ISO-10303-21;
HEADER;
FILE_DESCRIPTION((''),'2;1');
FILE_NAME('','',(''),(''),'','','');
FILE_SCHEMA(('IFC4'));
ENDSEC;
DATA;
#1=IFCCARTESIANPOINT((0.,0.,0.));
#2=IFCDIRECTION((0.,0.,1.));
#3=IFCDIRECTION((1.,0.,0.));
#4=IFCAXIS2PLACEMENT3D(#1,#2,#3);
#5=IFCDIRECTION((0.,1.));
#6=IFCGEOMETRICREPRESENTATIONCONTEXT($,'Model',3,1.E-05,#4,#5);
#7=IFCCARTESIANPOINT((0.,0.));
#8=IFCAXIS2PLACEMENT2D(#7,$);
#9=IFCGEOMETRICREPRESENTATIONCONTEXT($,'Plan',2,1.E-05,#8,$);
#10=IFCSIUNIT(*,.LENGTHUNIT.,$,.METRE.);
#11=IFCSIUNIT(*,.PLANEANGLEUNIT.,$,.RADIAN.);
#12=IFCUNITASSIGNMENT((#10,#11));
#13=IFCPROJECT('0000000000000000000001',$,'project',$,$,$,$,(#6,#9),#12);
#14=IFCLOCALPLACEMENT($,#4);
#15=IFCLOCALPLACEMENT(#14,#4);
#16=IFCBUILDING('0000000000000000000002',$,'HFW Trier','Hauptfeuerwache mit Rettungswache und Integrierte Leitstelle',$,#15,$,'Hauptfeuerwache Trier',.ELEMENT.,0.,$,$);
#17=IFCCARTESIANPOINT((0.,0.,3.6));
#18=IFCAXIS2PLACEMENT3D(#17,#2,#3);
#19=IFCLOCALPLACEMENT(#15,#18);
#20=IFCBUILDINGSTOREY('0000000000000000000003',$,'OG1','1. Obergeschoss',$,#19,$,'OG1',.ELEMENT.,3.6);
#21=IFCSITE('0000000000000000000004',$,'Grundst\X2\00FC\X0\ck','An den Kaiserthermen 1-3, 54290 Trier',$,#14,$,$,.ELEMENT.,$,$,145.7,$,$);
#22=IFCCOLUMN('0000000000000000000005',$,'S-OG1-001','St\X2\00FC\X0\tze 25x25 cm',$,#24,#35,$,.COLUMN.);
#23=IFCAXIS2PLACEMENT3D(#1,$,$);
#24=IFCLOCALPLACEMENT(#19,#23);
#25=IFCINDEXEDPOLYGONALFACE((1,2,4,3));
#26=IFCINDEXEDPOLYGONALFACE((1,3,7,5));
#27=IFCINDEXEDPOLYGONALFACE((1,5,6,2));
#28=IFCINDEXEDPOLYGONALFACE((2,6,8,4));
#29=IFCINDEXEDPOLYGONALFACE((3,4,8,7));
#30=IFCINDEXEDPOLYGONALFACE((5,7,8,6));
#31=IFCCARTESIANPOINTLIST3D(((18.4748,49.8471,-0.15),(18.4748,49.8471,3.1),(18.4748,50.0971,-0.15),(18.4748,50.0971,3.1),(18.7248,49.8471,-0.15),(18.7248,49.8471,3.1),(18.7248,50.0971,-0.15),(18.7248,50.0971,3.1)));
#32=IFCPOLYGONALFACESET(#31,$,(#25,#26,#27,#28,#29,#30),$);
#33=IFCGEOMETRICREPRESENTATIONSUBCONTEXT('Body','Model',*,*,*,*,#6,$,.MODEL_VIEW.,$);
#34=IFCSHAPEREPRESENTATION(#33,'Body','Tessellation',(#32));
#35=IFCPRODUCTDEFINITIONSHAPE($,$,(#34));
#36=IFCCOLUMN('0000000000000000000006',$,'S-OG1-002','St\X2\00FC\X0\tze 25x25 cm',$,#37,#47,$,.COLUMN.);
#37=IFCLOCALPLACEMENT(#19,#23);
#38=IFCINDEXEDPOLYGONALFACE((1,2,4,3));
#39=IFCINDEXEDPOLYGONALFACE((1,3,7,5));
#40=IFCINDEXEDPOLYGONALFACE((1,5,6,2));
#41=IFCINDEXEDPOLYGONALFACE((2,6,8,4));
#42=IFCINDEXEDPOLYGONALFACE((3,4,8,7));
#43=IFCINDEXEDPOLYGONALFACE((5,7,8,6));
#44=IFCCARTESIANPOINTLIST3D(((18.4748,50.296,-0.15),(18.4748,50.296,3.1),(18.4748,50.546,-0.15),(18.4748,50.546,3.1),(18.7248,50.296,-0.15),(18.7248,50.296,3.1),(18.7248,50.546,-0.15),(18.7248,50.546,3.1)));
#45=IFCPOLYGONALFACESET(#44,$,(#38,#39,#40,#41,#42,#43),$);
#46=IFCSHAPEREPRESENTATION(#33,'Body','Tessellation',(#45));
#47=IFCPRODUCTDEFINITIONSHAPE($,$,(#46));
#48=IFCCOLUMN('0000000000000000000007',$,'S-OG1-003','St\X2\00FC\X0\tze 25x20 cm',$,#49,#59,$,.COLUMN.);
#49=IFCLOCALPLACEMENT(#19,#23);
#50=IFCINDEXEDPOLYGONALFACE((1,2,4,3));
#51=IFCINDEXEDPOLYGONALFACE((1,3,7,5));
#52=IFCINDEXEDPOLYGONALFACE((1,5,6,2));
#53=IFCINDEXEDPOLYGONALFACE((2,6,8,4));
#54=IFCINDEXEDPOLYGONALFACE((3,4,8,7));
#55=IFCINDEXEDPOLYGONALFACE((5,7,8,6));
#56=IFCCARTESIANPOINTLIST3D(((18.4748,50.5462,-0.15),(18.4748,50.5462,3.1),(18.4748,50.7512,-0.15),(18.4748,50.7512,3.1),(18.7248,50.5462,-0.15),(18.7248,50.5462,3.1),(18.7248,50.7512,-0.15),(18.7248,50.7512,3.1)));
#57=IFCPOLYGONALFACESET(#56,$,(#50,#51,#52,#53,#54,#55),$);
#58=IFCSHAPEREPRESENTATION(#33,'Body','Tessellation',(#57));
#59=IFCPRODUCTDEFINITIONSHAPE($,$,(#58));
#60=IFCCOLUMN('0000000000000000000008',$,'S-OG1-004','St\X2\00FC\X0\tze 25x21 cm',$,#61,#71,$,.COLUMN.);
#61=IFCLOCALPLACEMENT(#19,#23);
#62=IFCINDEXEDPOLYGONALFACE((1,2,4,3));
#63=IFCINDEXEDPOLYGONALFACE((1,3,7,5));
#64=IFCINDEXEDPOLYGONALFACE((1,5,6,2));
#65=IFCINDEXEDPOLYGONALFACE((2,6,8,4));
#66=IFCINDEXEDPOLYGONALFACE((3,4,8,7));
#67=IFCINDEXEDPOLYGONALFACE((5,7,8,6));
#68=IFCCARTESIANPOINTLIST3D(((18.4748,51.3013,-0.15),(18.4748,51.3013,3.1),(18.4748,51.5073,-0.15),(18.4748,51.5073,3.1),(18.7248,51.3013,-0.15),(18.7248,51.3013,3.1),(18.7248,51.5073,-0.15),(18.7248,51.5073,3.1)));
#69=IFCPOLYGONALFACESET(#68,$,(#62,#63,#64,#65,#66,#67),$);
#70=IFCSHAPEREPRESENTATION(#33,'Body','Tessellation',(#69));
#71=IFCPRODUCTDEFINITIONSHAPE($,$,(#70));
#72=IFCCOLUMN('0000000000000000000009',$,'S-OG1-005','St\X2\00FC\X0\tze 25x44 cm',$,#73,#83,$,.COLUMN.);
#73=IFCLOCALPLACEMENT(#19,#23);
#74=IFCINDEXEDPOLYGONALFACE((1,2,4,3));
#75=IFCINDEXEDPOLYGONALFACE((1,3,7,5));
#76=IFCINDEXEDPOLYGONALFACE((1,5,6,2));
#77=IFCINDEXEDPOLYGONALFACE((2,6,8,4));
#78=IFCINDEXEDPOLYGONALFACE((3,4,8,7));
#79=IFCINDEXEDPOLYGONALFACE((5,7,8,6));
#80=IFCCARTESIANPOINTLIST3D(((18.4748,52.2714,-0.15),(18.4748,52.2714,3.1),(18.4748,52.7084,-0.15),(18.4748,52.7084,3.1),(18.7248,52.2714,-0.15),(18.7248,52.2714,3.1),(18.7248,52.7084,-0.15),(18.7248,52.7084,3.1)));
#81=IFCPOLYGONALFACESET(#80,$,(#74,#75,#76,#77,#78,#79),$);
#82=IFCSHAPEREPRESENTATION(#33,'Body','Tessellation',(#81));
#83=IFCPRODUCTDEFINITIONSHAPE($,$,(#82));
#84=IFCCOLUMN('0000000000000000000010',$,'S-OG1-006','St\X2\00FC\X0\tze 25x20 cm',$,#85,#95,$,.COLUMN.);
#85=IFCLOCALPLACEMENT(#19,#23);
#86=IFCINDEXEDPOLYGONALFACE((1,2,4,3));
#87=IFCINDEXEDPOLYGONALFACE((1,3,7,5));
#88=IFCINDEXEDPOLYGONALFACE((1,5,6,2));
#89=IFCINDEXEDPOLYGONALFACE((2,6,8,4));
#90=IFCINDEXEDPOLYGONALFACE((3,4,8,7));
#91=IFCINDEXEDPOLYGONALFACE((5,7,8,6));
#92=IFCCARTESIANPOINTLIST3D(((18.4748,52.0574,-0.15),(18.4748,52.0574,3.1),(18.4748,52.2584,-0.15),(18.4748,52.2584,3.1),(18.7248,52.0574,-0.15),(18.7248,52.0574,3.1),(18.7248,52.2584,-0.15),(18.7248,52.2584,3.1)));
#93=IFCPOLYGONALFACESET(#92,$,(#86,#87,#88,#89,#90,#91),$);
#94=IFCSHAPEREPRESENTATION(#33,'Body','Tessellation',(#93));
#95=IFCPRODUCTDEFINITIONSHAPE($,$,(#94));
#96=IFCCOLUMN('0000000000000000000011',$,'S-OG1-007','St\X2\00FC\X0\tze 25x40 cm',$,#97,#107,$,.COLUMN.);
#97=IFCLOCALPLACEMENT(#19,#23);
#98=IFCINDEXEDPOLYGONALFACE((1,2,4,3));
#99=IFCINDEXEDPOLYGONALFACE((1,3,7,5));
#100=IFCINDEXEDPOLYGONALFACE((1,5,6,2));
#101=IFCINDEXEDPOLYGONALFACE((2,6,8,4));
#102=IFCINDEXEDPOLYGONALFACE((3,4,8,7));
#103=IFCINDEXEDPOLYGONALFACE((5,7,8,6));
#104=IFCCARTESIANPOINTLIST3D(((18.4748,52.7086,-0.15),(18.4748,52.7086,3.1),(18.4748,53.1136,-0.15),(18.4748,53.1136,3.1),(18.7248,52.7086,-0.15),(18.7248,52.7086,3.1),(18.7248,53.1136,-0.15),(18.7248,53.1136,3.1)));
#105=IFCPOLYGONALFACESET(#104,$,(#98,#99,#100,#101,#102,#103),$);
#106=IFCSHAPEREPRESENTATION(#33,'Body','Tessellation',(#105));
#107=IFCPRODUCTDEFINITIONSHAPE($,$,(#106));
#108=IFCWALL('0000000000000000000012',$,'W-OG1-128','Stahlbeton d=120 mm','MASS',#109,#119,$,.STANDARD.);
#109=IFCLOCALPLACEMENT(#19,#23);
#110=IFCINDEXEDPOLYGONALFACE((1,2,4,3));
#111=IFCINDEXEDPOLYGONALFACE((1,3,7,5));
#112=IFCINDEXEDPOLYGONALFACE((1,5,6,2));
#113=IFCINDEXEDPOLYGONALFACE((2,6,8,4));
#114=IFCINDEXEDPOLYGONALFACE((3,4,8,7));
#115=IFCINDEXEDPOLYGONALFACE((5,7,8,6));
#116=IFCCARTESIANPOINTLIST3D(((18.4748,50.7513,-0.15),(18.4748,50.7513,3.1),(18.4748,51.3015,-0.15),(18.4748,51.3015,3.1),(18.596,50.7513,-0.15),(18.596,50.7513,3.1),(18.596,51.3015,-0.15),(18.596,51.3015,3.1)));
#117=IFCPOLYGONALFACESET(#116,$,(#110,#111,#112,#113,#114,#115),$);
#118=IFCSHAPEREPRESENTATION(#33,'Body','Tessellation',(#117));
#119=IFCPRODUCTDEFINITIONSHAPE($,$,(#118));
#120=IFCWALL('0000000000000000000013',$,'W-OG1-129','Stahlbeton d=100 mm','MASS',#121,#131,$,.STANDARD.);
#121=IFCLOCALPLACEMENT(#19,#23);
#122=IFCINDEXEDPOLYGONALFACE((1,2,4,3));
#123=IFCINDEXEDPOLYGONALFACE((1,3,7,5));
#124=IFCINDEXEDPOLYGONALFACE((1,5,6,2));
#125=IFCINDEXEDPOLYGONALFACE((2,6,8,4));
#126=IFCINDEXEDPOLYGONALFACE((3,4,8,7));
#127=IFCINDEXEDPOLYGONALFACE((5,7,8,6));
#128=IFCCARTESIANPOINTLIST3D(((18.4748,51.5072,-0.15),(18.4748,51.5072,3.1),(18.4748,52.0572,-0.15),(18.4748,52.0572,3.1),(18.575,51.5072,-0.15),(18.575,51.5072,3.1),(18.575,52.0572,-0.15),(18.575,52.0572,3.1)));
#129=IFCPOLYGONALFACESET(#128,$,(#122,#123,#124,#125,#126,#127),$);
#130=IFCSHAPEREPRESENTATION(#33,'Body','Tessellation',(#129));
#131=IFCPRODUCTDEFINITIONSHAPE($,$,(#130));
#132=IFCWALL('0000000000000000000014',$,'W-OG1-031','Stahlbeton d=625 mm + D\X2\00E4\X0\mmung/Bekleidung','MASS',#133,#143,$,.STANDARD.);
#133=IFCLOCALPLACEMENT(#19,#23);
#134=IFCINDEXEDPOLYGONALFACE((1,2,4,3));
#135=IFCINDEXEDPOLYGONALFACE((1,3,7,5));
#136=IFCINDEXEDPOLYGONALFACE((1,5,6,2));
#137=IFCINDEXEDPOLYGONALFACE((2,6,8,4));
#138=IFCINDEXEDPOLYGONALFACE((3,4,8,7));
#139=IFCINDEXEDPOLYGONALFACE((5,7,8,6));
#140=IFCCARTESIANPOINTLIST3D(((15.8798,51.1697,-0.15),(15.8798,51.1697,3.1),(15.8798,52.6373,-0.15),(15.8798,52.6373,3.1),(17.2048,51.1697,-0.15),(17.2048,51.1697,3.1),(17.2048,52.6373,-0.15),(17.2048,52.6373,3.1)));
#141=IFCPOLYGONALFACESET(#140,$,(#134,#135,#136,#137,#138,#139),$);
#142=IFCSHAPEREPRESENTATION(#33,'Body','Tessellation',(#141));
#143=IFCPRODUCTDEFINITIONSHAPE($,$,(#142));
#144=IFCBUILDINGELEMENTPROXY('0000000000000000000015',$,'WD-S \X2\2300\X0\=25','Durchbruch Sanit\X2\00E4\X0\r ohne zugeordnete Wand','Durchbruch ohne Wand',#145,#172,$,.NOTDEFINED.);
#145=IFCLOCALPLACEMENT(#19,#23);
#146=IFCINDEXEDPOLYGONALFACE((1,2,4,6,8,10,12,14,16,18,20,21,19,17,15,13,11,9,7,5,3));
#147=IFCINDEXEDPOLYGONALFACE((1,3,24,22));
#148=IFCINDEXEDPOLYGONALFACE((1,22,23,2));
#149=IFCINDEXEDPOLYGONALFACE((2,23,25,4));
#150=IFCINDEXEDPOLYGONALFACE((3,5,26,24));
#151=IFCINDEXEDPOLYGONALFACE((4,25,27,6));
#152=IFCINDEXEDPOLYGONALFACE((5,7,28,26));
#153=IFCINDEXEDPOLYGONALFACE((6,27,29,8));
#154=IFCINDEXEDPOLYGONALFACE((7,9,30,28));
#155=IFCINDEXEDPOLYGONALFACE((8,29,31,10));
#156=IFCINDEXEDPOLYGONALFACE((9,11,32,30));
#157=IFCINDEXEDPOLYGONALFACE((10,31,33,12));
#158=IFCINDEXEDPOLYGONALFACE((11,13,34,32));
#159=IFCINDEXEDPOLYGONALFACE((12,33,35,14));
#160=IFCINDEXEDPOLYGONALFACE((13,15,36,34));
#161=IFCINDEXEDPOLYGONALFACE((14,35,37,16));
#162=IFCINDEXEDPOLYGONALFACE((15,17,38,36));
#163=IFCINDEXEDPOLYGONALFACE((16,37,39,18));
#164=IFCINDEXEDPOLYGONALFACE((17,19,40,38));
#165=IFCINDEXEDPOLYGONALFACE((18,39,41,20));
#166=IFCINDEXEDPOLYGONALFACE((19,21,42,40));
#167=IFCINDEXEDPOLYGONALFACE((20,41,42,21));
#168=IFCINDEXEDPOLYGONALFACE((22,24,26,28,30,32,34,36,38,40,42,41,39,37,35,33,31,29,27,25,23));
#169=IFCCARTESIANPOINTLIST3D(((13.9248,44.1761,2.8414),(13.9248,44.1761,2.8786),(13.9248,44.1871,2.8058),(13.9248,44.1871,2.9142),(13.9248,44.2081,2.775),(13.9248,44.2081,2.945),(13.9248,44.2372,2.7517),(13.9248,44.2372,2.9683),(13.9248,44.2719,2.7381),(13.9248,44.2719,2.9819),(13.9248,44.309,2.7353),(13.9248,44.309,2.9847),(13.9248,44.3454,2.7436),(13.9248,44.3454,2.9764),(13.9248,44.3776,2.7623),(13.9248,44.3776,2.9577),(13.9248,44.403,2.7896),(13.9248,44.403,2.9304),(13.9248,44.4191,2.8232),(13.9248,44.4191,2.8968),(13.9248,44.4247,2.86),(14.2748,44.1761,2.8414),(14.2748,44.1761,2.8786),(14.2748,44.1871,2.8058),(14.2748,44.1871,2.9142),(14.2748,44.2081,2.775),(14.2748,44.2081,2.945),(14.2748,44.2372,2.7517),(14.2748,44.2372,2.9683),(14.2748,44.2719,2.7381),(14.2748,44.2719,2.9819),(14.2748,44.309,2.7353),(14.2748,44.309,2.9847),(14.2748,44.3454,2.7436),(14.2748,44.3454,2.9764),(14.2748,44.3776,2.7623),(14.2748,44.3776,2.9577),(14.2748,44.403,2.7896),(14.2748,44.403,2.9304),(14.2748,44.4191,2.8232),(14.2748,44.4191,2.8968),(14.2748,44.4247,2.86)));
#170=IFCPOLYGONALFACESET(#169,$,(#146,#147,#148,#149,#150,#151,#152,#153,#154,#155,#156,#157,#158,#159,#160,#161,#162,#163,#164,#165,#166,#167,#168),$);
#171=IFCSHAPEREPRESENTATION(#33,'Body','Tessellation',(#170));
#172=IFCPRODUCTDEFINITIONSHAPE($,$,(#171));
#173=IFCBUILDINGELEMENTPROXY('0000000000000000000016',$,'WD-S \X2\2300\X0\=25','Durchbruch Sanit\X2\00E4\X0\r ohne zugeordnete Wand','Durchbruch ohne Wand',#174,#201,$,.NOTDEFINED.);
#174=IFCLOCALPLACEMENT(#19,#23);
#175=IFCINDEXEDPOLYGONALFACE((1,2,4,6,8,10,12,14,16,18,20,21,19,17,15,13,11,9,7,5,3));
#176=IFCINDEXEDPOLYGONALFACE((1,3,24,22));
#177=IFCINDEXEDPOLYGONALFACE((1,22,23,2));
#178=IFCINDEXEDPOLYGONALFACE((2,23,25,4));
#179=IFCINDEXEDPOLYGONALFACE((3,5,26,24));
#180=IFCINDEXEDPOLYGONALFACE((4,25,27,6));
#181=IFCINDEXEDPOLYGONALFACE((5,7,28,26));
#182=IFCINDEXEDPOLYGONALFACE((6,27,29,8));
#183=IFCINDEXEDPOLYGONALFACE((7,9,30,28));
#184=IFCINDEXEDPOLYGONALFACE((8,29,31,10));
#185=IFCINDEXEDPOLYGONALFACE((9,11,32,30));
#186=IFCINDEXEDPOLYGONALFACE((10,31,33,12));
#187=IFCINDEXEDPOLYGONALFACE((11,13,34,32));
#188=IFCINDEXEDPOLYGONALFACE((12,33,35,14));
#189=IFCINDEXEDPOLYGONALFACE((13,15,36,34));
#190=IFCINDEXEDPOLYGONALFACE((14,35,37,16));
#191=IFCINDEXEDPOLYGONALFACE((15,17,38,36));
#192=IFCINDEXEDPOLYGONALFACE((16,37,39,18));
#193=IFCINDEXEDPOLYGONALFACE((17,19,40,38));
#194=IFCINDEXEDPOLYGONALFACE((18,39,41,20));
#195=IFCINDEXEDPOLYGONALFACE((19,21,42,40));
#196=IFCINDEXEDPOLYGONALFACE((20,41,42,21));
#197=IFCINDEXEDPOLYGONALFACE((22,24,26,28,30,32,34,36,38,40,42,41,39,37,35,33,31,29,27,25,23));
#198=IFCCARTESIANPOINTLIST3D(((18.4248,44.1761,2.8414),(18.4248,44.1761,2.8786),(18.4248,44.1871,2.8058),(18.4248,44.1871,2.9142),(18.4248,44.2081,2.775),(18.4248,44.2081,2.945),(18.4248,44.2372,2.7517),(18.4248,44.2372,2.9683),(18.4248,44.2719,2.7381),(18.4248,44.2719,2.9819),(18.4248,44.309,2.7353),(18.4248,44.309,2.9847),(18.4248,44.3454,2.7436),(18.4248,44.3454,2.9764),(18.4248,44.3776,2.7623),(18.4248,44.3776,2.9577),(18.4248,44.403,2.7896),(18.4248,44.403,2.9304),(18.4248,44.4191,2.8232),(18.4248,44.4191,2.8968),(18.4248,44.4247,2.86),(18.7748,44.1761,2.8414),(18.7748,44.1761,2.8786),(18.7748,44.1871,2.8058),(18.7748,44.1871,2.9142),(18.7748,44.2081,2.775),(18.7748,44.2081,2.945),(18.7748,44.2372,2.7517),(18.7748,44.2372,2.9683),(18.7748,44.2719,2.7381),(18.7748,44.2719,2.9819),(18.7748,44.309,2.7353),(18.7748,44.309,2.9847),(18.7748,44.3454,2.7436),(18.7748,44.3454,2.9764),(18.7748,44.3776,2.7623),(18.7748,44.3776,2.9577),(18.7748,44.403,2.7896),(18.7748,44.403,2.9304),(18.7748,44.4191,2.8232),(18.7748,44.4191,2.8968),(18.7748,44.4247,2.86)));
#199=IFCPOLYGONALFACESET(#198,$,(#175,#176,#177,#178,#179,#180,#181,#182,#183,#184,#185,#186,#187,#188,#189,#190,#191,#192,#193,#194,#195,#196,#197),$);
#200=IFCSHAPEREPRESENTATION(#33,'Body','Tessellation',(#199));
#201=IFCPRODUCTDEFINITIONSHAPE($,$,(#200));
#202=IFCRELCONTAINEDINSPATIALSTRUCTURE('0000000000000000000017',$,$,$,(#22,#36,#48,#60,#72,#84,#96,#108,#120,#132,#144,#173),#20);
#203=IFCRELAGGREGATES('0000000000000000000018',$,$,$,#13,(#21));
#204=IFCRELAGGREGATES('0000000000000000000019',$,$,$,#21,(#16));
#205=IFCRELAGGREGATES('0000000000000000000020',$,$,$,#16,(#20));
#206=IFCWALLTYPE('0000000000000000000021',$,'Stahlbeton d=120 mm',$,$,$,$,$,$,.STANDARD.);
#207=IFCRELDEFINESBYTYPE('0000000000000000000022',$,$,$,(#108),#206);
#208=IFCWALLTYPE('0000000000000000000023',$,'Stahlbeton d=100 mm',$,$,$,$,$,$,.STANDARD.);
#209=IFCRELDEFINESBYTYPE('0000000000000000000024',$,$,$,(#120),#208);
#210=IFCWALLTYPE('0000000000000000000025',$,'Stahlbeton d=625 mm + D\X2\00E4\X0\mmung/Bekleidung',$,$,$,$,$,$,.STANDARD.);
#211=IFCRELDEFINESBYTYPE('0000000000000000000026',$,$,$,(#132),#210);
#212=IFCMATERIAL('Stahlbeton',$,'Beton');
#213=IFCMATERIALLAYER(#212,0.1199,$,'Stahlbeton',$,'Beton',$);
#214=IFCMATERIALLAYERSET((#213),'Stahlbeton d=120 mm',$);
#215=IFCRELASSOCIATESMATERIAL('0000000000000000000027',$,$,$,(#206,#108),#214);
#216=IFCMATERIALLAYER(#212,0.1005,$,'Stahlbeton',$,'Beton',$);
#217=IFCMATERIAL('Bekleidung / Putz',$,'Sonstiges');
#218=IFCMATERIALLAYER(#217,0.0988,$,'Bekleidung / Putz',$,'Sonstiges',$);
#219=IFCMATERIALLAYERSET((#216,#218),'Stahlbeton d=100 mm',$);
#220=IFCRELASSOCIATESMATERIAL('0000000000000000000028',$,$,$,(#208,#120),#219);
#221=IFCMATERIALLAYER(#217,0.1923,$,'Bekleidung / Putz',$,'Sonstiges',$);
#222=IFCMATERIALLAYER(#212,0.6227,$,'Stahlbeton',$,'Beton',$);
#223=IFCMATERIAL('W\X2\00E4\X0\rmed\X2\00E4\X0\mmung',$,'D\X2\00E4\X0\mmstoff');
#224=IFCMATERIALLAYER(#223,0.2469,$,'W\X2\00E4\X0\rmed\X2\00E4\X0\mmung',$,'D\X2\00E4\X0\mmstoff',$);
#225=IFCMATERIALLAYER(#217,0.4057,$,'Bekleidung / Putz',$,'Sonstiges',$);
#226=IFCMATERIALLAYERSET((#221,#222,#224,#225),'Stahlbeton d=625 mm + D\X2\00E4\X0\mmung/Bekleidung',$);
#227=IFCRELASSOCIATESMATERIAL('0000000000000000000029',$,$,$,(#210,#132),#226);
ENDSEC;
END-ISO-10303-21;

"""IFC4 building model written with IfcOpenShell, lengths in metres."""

from ifc_helpers import new_model, si_unit, direction, frame, frame_2d, origin_with_axes, origin_2d, place, context, subcontext, project, spatial, rectangle, circle, extrude, material, layer, layer_set, layer_usage, type_object, element, save


model = new_model("IFC4")

# Units and contexts
model_context = context("Model", 3, precision=1e-05, world=origin_with_axes(), true_north=direction((0.0, 1.0)))
plan_context = context("Plan", 2, precision=1e-05, world=origin_2d())
body_context = subcontext(model_context, "Body", "Model", "MODEL_VIEW")
ifc_project = project(units=[si_unit("LENGTHUNIT", "METRE"), si_unit("PLANEANGLEUNIT", "RADIAN")], contexts=[model_context, plan_context])

# Site, building, storey
site_placement = place(None, origin_with_axes())
site = spatial("IfcSite", under=ifc_project, at=site_placement, Name="Grundstück", Description="An den Kaiserthermen 1-3, 54290 Trier", CompositionType="ELEMENT", RefElevation=145.7)
building_placement = place(site_placement, origin_with_axes())
building = spatial("IfcBuilding", under=site, at=building_placement, Name="HFW Trier", Description="Hauptfeuerwache mit Rettungswache und Integrierte Leitstelle", LongName="Hauptfeuerwache Trier", CompositionType="ELEMENT", ElevationOfRefHeight=0.0)
storey_placement = place(building_placement, frame((0.0, 0.0, 3.6), z_axis=(0.0, 0.0, 1.0), x_axis=(1.0, 0.0, 0.0)))
storey = spatial("IfcBuildingStorey", under=building, at=storey_placement, Name="OG1", Description="1. Obergeschoss", LongName="OG1", CompositionType="ELEMENT", Elevation=3.6)

# Columns
for number, where, z_axis, x_axis, name in (
    (1, (18.4748, 49.9721, -0.15), (0.0, 0.0, 1.0), (1.0, 0.0, 0.0), "S-OG1-001"),
    (2, (18.4748, 50.421, -0.15), (0.0, 0.0, 1.0), (1.0, 0.0, 0.0), "S-OG1-002"),
):
    element("IfcColumn", number, at=place(storey_placement, frame(where, z_axis=z_axis, x_axis=x_axis)), inside=storey, Name=name, Description="Stütze 25x25 cm", PredefinedType="COLUMN", context=body_context, shape_type="SweptSolid", body=[
        extrude(rectangle(XDim=0.25, YDim=0.25, at=frame_2d((0.125, 0.0))), origin_with_axes(), (0.0, 0.0, 1.0), 3.25),
    ])
column_1_placement = place(storey_placement, frame((18.4748, 50.6487, -0.15), z_axis=(0.0, 0.0, 1.0), x_axis=(1.0, 0.0, 0.0)))
element("IfcColumn", 3, at=column_1_placement, inside=storey, Name="S-OG1-003", Description="Stütze 25x20 cm", PredefinedType="COLUMN", context=body_context, shape_type="SweptSolid", body=[
    extrude(rectangle(XDim=0.25, YDim=0.205, at=frame_2d((0.125, 0.0))), origin_with_axes(), (0.0, 0.0, 1.0), 3.25),
])
column_2_placement = place(storey_placement, frame((18.4748, 51.4043, -0.15), z_axis=(0.0, 0.0, 1.0), x_axis=(1.0, 0.0, 0.0)))
element("IfcColumn", 4, at=column_2_placement, inside=storey, Name="S-OG1-004", Description="Stütze 25x21 cm", PredefinedType="COLUMN", context=body_context, shape_type="SweptSolid", body=[
    extrude(rectangle(XDim=0.25, YDim=0.206, at=frame_2d((0.125, 0.0))), origin_with_axes(), (0.0, 0.0, 1.0), 3.25),
])
column_3_placement = place(storey_placement, frame((18.4748, 52.4899, -0.15), z_axis=(0.0, 0.0, 1.0), x_axis=(1.0, 0.0, 0.0)))
element("IfcColumn", 5, at=column_3_placement, inside=storey, Name="S-OG1-005", Description="Stütze 25x44 cm", PredefinedType="COLUMN", context=body_context, shape_type="SweptSolid", body=[
    extrude(rectangle(XDim=0.25, YDim=0.437, at=frame_2d((0.125, 0.0))), origin_with_axes(), (0.0, 0.0, 1.0), 3.25),
])
column_4_placement = place(storey_placement, frame((18.4748, 52.1579, -0.15), z_axis=(0.0, 0.0, 1.0), x_axis=(1.0, 0.0, 0.0)))
element("IfcColumn", 6, at=column_4_placement, inside=storey, Name="S-OG1-006", Description="Stütze 25x20 cm", PredefinedType="COLUMN", context=body_context, shape_type="SweptSolid", body=[
    extrude(rectangle(XDim=0.25, YDim=0.201, at=frame_2d((0.125, 0.0))), origin_with_axes(), (0.0, 0.0, 1.0), 3.25),
])
column_5_placement = place(storey_placement, frame((18.4748, 52.9111, -0.15), z_axis=(0.0, 0.0, 1.0), x_axis=(1.0, 0.0, 0.0)))
element("IfcColumn", 7, at=column_5_placement, inside=storey, Name="S-OG1-007", Description="Stütze 25x40 cm", PredefinedType="COLUMN", context=body_context, shape_type="SweptSolid", body=[
    extrude(rectangle(XDim=0.25, YDim=0.405, at=frame_2d((0.125, 0.0))), origin_with_axes(), (0.0, 0.0, 1.0), 3.25),
])

# Walls
ifc_material_1 = material(Name="Stahlbeton", Category="Beton")
ifc_layer_1 = layer(ifc_material_1, 0.1199, Name="Stahlbeton", Category="Beton")
ifc_layer_set_1 = layer_set([ifc_layer_1], Name="Stahlbeton d=120 mm")
ifc_layer_usage_1 = layer_usage(ifc_layer_set_1, "AXIS2", "POSITIVE", -0.0606)
wall_type_1 = type_object("IfcWallType", Name="Stahlbeton d=120 mm", PredefinedType="STANDARD", material=ifc_layer_set_1)
wall_1_placement = place(storey_placement, frame((18.5354, 51.3015, -0.15), z_axis=(0.0, 0.0, 1.0), x_axis=(0.0, -1.0, 0.0)))
element("IfcWall", 8, at=wall_1_placement, inside=storey, type_object=wall_type_1, material=ifc_layer_usage_1, Name="W-OG1-128", Description="Stahlbeton d=120 mm", ObjectType="MASS", PredefinedType="STANDARD", context=body_context, shape_type="SweptSolid", body=[
    extrude(rectangle(XDim=0.5502, YDim=0.1212, at=frame_2d((0.2751, 0.0))), origin_with_axes(), (0.0, 0.0, 1.0), 3.25),
])
ifc_layer_2 = layer(ifc_material_1, 0.1005, Name="Stahlbeton", Category="Beton")
ifc_material_2 = material(Name="Bekleidung / Putz", Category="Sonstiges")
ifc_layer_3 = layer(ifc_material_2, 0.0988, Name="Bekleidung / Putz", Category="Sonstiges")
ifc_layer_set_2 = layer_set([ifc_layer_2, ifc_layer_3], Name="Stahlbeton d=100 mm")
ifc_layer_usage_2 = layer_usage(ifc_layer_set_2, "AXIS2", "POSITIVE", -0.0501)
wall_type_2 = type_object("IfcWallType", Name="Stahlbeton d=100 mm", PredefinedType="STANDARD", material=ifc_layer_set_2)
wall_2_placement = place(storey_placement, frame((18.5249, 52.0572, -0.15), z_axis=(0.0, 0.0, 1.0), x_axis=(0.0, -1.0, 0.0)))
element("IfcWall", 9, at=wall_2_placement, inside=storey, type_object=wall_type_2, material=ifc_layer_usage_2, Name="W-OG1-129", Description="Stahlbeton d=100 mm", ObjectType="MASS", PredefinedType="STANDARD", context=body_context, shape_type="SweptSolid", body=[
    extrude(rectangle(XDim=0.55, YDim=0.1002, at=frame_2d((0.275, 0.0))), origin_with_axes(), (0.0, 0.0, 1.0), 3.25),
])
ifc_layer_4 = layer(ifc_material_2, 0.1923, Name="Bekleidung / Putz", Category="Sonstiges")
ifc_layer_5 = layer(ifc_material_1, 0.6227, Name="Stahlbeton", Category="Beton")
ifc_material_3 = material(Name="Wärmedämmung", Category="Dämmstoff")
ifc_layer_6 = layer(ifc_material_3, 0.2469, Name="Wärmedämmung", Category="Dämmstoff")
ifc_layer_7 = layer(ifc_material_2, 0.4057, Name="Bekleidung / Putz", Category="Sonstiges")
ifc_layer_set_3 = layer_set([ifc_layer_4, ifc_layer_5, ifc_layer_6, ifc_layer_7], Name="Stahlbeton d=625 mm + Dämmung/Bekleidung")
ifc_layer_usage_3 = layer_usage(ifc_layer_set_3, "AXIS2", "POSITIVE", -0.7338)
wall_type_3 = type_object("IfcWallType", Name="Stahlbeton d=625 mm + Dämmung/Bekleidung", PredefinedType="STANDARD", material=ifc_layer_set_3)
wall_3_placement = place(storey_placement, frame((15.8798, 51.9035, -0.15), z_axis=(0.0, 0.0, 1.0), x_axis=(1.0, 0.0, 0.0)))
element("IfcWall", 10, at=wall_3_placement, inside=storey, type_object=wall_type_3, material=ifc_layer_usage_3, Name="W-OG1-031", Description="Stahlbeton d=625 mm + Dämmung/Bekleidung", ObjectType="MASS", PredefinedType="STANDARD", context=body_context, shape_type="SweptSolid", body=[
    extrude(rectangle(XDim=1.325, YDim=1.4676, at=frame_2d((0.6625, 0.0))), origin_with_axes(), (0.0, 0.0, 1.0), 3.25),
])

# Building element proxies
for number, where, z_axis, x_axis, name in (
    (11, (14.0998, 44.2997, 2.735), (0.0, 0.0, 1.0), (0.0, 1.0, 0.0), "WD-S ⌀=25"),
    (12, (18.5998, 44.2997, 2.735), (0.0, 0.0, 1.0), (0.0, 1.0, 0.0), "WD-S ⌀=25"),
):
    element("IfcBuildingElementProxy", number, at=place(storey_placement, frame(where, z_axis=z_axis, x_axis=x_axis)), inside=storey, Name=name, Description="Durchbruch Sanitär ohne zugeordnete Wand", ObjectType="Durchbruch ohne Wand", PredefinedType="NOTDEFINED", context=body_context, shape_type="SweptSolid", body=[
        extrude(circle(Radius=0.125, at=origin_2d()), frame((0.0, -0.175, 0.125), z_axis=(0.0, 1.0, 0.0), x_axis=(1.0, 0.0, 0.0)), (0.0, 0.0, 1.0), 0.35),
    ])

save(model, "model.ifc")
